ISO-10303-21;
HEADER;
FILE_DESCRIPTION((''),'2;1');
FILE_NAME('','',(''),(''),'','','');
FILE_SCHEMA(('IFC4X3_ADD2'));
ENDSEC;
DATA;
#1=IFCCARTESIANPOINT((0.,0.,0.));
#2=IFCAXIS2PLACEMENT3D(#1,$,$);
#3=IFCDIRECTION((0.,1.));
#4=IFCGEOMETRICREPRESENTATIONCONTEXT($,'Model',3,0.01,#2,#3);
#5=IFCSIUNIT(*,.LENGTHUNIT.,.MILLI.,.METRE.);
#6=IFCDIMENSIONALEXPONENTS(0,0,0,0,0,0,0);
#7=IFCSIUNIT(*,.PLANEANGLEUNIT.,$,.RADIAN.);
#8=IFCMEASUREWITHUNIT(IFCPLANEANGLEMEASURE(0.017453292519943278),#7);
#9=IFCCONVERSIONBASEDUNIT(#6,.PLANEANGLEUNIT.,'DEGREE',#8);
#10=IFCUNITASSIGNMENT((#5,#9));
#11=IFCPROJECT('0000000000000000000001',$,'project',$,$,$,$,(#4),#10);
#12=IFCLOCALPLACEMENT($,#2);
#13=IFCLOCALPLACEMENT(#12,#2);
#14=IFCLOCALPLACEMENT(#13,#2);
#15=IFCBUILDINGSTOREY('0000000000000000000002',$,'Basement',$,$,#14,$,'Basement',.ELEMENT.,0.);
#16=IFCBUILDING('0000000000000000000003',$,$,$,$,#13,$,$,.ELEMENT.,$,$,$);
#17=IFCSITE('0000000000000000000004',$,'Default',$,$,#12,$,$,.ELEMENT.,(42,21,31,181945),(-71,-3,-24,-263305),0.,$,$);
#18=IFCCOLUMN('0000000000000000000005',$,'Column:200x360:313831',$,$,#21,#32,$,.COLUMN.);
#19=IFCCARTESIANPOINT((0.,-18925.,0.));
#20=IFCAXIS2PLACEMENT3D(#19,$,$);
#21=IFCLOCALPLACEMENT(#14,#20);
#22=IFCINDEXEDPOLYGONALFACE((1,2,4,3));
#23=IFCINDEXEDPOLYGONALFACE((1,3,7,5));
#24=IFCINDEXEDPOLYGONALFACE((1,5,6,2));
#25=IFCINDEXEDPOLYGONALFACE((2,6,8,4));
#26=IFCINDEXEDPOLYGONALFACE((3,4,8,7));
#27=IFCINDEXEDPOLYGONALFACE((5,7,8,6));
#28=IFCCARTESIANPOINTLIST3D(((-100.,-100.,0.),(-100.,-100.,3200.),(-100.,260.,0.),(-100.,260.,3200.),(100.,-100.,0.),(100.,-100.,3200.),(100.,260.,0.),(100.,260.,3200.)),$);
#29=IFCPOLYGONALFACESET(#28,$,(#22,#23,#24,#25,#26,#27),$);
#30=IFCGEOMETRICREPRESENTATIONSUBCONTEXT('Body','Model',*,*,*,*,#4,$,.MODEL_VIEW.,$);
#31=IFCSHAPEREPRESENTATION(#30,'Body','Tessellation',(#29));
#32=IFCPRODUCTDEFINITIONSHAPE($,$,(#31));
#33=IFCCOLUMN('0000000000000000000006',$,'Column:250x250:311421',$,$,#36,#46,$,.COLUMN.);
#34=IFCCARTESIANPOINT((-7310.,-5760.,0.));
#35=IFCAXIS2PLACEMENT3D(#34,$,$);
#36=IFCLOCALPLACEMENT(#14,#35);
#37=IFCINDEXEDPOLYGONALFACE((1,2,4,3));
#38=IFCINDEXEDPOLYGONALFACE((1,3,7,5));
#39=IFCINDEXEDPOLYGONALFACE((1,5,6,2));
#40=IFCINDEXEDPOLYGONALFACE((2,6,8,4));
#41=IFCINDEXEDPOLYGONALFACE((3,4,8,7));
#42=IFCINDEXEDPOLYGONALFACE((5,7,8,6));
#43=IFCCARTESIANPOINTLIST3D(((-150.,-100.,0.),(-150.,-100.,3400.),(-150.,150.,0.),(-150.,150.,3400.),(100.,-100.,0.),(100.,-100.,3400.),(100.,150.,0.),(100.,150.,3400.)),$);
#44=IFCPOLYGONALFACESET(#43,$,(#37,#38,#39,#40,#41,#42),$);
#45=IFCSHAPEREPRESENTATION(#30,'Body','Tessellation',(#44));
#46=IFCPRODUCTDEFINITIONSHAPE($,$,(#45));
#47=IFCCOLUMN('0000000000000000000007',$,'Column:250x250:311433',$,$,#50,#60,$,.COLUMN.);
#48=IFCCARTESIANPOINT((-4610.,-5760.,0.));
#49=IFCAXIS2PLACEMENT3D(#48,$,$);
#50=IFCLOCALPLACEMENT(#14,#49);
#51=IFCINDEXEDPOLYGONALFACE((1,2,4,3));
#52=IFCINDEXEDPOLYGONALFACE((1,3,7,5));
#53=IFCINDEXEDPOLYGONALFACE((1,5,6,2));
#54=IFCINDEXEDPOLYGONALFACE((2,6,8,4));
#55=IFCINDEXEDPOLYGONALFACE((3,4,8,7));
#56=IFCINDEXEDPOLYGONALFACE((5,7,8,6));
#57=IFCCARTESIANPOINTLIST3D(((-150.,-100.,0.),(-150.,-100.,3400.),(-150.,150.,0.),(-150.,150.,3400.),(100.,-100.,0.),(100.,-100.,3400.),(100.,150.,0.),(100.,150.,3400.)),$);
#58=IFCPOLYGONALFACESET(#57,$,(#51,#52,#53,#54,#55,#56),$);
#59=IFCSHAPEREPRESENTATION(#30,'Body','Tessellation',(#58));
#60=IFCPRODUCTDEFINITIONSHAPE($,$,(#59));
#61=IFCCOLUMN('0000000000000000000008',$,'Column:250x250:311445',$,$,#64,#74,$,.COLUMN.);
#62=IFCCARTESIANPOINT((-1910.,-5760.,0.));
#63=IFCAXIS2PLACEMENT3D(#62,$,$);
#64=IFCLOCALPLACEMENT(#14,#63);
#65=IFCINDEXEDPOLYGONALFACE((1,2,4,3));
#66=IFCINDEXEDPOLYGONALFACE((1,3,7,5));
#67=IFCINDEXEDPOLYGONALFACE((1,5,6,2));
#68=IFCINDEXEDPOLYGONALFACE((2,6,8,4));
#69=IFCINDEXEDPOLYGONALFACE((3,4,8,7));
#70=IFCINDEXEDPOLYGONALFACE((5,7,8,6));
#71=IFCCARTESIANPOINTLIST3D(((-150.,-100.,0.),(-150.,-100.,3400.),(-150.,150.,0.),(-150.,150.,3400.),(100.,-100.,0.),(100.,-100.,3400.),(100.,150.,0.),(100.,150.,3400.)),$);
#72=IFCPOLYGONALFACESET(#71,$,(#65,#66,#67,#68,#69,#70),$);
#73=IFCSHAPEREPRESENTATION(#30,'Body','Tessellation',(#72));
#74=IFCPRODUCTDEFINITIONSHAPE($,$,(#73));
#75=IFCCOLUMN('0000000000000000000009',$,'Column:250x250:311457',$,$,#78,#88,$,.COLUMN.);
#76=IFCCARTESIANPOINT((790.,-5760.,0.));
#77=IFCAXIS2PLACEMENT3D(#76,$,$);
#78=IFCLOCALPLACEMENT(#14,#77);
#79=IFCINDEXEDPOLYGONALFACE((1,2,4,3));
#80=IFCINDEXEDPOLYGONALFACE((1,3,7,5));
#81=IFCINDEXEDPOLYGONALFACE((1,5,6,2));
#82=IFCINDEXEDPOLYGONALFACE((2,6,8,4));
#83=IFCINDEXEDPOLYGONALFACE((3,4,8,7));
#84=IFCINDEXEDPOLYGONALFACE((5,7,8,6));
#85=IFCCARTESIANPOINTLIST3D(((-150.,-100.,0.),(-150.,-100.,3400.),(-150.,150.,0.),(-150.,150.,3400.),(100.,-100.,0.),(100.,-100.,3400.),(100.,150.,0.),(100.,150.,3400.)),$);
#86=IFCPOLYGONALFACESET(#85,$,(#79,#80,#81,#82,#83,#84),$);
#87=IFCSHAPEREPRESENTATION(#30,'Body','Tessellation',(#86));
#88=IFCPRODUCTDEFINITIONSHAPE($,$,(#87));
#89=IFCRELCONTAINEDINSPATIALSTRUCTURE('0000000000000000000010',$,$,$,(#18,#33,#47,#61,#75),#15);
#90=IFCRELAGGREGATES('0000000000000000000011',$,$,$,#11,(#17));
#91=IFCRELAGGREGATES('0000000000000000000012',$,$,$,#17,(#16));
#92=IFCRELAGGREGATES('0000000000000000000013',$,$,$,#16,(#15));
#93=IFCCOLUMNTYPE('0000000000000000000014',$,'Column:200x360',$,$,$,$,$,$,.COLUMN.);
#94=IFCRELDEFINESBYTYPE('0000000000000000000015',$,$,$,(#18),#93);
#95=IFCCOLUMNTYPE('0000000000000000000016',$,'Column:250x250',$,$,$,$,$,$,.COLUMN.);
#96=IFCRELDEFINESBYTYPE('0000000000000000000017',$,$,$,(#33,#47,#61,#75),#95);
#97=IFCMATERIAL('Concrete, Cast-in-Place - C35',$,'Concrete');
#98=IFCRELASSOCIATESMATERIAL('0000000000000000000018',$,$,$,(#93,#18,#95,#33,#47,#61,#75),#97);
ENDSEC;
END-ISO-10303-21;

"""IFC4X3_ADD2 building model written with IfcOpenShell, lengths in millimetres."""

from ifc_helpers import new_model, entity, si_unit, converted_unit, direction, frame, origin, origin_2d_with_axis, place, context, subcontext, project, spatial, rectangle, extrude, source, transform, mapped, material, material_profile, profile_set, profile_usage, type_object, type_shapes, element, save


model = new_model("IFC4X3_ADD2")

# Units and contexts
model_context = context("Model", 3, precision=0.01, world=origin(), true_north=direction((0.0, 1.0)))
body_context = subcontext(model_context, "Body", "Model", "MODEL_VIEW")
ifc_project = project(units=[si_unit("LENGTHUNIT", "METRE", prefix="MILLI"), converted_unit("PLANEANGLEUNIT", "DEGREE", entity("IfcPlaneAngleMeasure", 0.017453292519943278), si_unit("PLANEANGLEUNIT", "RADIAN"), dimensions=[0, 0, 0, 0, 0, 0, 0])], contexts=[model_context])

# Site, building, storey
site_placement = place(None, origin())
site = spatial("IfcSite", under=ifc_project, at=site_placement, Name="Default", CompositionType="ELEMENT", RefLatitude=(42, 21, 31, 181945), RefLongitude=(-71, -3, -24, -263305), RefElevation=0.0)
building_placement = place(site_placement, origin())
building = spatial("IfcBuilding", under=site, at=building_placement, CompositionType="ELEMENT")
storey_placement = place(building_placement, origin())
storey = spatial("IfcBuildingStorey", under=building, at=storey_placement, Name="Basement", LongName="Basement", CompositionType="ELEMENT", Elevation=0.0)

# Columns
ifc_material = material(Name="Concrete, Cast-in-Place - C35", Category="Concrete")
ifc_material_profile_1 = material_profile(ifc_material, rectangle(XDim=200.0, YDim=360.0, at=origin_2d_with_axis()), Name="200x360")
ifc_profile_set_1 = profile_set([ifc_material_profile_1], Name="200x360")
ifc_profile_usage_1 = profile_usage(ifc_profile_set_1)
column_type_1 = type_object("IfcColumnType", Name="Column:200x360", PredefinedType="COLUMN", material=ifc_profile_set_1)
shared_shape_1 = source(origin(), body_context, "Body", "SweptSolid", [
    extrude(rectangle(XDim=200.0, YDim=360.0, at=origin_2d_with_axis()), frame((0.0, 80.0, 0.0), z_axis=(0.0, 0.0, 1.0), x_axis=(-1.0, 0.0, 0.0)), (0.0, 0.0, 1.0), 3200.0),
])
type_shapes(column_type_1, [shared_shape_1])
for number, where, name in (
    (1, (0.0, -18925.0, 0.0), "Column:200x360:313831"),
):
    element("IfcColumn", number, at=place(storey_placement, frame(where)), inside=storey, type_object=column_type_1, material=ifc_profile_usage_1, Name=name, PredefinedType="COLUMN", context=body_context, shape_type="MappedRepresentation", body=[
        mapped(shared_shape_1, transform((0.0, 0.0, 0.0), scale=1.0)),
    ])
ifc_material_profile_2 = material_profile(ifc_material, rectangle(XDim=250.0, YDim=250.0, at=origin_2d_with_axis()), Name="250x250")
ifc_profile_set_2 = profile_set([ifc_material_profile_2], Name="250x250")
ifc_profile_usage_2 = profile_usage(ifc_profile_set_2)
column_type_2 = type_object("IfcColumnType", Name="Column:250x250", PredefinedType="COLUMN", material=ifc_profile_set_2)
shared_shape_2 = source(origin(), body_context, "Body", "SweptSolid", [
    extrude(rectangle(XDim=250.0, YDim=250.0, at=origin_2d_with_axis()), frame((-25.0, 25.0, 0.0), z_axis=(0.0, 0.0, 1.0), x_axis=(-1.0, 0.0, 0.0)), (0.0, 0.0, 1.0), 3400.0),
])
type_shapes(column_type_2, [shared_shape_2])
for number, where, name in (
    (2, (-7310.0, -5760.0, 0.0), "Column:250x250:311421"),
    (3, (-4610.0, -5760.0, 0.0), "Column:250x250:311433"),
    (4, (-1910.0, -5760.0, 0.0), "Column:250x250:311445"),
    (5, (790.0, -5760.0, 0.0), "Column:250x250:311457"),
):
    element("IfcColumn", number, at=place(storey_placement, frame(where)), inside=storey, type_object=column_type_2, material=ifc_profile_usage_2, Name=name, PredefinedType="COLUMN", context=body_context, shape_type="MappedRepresentation", body=[
        mapped(shared_shape_2, transform((0.0, 0.0, 0.0), scale=1.0)),
    ])

save(model, "model.ifc")
